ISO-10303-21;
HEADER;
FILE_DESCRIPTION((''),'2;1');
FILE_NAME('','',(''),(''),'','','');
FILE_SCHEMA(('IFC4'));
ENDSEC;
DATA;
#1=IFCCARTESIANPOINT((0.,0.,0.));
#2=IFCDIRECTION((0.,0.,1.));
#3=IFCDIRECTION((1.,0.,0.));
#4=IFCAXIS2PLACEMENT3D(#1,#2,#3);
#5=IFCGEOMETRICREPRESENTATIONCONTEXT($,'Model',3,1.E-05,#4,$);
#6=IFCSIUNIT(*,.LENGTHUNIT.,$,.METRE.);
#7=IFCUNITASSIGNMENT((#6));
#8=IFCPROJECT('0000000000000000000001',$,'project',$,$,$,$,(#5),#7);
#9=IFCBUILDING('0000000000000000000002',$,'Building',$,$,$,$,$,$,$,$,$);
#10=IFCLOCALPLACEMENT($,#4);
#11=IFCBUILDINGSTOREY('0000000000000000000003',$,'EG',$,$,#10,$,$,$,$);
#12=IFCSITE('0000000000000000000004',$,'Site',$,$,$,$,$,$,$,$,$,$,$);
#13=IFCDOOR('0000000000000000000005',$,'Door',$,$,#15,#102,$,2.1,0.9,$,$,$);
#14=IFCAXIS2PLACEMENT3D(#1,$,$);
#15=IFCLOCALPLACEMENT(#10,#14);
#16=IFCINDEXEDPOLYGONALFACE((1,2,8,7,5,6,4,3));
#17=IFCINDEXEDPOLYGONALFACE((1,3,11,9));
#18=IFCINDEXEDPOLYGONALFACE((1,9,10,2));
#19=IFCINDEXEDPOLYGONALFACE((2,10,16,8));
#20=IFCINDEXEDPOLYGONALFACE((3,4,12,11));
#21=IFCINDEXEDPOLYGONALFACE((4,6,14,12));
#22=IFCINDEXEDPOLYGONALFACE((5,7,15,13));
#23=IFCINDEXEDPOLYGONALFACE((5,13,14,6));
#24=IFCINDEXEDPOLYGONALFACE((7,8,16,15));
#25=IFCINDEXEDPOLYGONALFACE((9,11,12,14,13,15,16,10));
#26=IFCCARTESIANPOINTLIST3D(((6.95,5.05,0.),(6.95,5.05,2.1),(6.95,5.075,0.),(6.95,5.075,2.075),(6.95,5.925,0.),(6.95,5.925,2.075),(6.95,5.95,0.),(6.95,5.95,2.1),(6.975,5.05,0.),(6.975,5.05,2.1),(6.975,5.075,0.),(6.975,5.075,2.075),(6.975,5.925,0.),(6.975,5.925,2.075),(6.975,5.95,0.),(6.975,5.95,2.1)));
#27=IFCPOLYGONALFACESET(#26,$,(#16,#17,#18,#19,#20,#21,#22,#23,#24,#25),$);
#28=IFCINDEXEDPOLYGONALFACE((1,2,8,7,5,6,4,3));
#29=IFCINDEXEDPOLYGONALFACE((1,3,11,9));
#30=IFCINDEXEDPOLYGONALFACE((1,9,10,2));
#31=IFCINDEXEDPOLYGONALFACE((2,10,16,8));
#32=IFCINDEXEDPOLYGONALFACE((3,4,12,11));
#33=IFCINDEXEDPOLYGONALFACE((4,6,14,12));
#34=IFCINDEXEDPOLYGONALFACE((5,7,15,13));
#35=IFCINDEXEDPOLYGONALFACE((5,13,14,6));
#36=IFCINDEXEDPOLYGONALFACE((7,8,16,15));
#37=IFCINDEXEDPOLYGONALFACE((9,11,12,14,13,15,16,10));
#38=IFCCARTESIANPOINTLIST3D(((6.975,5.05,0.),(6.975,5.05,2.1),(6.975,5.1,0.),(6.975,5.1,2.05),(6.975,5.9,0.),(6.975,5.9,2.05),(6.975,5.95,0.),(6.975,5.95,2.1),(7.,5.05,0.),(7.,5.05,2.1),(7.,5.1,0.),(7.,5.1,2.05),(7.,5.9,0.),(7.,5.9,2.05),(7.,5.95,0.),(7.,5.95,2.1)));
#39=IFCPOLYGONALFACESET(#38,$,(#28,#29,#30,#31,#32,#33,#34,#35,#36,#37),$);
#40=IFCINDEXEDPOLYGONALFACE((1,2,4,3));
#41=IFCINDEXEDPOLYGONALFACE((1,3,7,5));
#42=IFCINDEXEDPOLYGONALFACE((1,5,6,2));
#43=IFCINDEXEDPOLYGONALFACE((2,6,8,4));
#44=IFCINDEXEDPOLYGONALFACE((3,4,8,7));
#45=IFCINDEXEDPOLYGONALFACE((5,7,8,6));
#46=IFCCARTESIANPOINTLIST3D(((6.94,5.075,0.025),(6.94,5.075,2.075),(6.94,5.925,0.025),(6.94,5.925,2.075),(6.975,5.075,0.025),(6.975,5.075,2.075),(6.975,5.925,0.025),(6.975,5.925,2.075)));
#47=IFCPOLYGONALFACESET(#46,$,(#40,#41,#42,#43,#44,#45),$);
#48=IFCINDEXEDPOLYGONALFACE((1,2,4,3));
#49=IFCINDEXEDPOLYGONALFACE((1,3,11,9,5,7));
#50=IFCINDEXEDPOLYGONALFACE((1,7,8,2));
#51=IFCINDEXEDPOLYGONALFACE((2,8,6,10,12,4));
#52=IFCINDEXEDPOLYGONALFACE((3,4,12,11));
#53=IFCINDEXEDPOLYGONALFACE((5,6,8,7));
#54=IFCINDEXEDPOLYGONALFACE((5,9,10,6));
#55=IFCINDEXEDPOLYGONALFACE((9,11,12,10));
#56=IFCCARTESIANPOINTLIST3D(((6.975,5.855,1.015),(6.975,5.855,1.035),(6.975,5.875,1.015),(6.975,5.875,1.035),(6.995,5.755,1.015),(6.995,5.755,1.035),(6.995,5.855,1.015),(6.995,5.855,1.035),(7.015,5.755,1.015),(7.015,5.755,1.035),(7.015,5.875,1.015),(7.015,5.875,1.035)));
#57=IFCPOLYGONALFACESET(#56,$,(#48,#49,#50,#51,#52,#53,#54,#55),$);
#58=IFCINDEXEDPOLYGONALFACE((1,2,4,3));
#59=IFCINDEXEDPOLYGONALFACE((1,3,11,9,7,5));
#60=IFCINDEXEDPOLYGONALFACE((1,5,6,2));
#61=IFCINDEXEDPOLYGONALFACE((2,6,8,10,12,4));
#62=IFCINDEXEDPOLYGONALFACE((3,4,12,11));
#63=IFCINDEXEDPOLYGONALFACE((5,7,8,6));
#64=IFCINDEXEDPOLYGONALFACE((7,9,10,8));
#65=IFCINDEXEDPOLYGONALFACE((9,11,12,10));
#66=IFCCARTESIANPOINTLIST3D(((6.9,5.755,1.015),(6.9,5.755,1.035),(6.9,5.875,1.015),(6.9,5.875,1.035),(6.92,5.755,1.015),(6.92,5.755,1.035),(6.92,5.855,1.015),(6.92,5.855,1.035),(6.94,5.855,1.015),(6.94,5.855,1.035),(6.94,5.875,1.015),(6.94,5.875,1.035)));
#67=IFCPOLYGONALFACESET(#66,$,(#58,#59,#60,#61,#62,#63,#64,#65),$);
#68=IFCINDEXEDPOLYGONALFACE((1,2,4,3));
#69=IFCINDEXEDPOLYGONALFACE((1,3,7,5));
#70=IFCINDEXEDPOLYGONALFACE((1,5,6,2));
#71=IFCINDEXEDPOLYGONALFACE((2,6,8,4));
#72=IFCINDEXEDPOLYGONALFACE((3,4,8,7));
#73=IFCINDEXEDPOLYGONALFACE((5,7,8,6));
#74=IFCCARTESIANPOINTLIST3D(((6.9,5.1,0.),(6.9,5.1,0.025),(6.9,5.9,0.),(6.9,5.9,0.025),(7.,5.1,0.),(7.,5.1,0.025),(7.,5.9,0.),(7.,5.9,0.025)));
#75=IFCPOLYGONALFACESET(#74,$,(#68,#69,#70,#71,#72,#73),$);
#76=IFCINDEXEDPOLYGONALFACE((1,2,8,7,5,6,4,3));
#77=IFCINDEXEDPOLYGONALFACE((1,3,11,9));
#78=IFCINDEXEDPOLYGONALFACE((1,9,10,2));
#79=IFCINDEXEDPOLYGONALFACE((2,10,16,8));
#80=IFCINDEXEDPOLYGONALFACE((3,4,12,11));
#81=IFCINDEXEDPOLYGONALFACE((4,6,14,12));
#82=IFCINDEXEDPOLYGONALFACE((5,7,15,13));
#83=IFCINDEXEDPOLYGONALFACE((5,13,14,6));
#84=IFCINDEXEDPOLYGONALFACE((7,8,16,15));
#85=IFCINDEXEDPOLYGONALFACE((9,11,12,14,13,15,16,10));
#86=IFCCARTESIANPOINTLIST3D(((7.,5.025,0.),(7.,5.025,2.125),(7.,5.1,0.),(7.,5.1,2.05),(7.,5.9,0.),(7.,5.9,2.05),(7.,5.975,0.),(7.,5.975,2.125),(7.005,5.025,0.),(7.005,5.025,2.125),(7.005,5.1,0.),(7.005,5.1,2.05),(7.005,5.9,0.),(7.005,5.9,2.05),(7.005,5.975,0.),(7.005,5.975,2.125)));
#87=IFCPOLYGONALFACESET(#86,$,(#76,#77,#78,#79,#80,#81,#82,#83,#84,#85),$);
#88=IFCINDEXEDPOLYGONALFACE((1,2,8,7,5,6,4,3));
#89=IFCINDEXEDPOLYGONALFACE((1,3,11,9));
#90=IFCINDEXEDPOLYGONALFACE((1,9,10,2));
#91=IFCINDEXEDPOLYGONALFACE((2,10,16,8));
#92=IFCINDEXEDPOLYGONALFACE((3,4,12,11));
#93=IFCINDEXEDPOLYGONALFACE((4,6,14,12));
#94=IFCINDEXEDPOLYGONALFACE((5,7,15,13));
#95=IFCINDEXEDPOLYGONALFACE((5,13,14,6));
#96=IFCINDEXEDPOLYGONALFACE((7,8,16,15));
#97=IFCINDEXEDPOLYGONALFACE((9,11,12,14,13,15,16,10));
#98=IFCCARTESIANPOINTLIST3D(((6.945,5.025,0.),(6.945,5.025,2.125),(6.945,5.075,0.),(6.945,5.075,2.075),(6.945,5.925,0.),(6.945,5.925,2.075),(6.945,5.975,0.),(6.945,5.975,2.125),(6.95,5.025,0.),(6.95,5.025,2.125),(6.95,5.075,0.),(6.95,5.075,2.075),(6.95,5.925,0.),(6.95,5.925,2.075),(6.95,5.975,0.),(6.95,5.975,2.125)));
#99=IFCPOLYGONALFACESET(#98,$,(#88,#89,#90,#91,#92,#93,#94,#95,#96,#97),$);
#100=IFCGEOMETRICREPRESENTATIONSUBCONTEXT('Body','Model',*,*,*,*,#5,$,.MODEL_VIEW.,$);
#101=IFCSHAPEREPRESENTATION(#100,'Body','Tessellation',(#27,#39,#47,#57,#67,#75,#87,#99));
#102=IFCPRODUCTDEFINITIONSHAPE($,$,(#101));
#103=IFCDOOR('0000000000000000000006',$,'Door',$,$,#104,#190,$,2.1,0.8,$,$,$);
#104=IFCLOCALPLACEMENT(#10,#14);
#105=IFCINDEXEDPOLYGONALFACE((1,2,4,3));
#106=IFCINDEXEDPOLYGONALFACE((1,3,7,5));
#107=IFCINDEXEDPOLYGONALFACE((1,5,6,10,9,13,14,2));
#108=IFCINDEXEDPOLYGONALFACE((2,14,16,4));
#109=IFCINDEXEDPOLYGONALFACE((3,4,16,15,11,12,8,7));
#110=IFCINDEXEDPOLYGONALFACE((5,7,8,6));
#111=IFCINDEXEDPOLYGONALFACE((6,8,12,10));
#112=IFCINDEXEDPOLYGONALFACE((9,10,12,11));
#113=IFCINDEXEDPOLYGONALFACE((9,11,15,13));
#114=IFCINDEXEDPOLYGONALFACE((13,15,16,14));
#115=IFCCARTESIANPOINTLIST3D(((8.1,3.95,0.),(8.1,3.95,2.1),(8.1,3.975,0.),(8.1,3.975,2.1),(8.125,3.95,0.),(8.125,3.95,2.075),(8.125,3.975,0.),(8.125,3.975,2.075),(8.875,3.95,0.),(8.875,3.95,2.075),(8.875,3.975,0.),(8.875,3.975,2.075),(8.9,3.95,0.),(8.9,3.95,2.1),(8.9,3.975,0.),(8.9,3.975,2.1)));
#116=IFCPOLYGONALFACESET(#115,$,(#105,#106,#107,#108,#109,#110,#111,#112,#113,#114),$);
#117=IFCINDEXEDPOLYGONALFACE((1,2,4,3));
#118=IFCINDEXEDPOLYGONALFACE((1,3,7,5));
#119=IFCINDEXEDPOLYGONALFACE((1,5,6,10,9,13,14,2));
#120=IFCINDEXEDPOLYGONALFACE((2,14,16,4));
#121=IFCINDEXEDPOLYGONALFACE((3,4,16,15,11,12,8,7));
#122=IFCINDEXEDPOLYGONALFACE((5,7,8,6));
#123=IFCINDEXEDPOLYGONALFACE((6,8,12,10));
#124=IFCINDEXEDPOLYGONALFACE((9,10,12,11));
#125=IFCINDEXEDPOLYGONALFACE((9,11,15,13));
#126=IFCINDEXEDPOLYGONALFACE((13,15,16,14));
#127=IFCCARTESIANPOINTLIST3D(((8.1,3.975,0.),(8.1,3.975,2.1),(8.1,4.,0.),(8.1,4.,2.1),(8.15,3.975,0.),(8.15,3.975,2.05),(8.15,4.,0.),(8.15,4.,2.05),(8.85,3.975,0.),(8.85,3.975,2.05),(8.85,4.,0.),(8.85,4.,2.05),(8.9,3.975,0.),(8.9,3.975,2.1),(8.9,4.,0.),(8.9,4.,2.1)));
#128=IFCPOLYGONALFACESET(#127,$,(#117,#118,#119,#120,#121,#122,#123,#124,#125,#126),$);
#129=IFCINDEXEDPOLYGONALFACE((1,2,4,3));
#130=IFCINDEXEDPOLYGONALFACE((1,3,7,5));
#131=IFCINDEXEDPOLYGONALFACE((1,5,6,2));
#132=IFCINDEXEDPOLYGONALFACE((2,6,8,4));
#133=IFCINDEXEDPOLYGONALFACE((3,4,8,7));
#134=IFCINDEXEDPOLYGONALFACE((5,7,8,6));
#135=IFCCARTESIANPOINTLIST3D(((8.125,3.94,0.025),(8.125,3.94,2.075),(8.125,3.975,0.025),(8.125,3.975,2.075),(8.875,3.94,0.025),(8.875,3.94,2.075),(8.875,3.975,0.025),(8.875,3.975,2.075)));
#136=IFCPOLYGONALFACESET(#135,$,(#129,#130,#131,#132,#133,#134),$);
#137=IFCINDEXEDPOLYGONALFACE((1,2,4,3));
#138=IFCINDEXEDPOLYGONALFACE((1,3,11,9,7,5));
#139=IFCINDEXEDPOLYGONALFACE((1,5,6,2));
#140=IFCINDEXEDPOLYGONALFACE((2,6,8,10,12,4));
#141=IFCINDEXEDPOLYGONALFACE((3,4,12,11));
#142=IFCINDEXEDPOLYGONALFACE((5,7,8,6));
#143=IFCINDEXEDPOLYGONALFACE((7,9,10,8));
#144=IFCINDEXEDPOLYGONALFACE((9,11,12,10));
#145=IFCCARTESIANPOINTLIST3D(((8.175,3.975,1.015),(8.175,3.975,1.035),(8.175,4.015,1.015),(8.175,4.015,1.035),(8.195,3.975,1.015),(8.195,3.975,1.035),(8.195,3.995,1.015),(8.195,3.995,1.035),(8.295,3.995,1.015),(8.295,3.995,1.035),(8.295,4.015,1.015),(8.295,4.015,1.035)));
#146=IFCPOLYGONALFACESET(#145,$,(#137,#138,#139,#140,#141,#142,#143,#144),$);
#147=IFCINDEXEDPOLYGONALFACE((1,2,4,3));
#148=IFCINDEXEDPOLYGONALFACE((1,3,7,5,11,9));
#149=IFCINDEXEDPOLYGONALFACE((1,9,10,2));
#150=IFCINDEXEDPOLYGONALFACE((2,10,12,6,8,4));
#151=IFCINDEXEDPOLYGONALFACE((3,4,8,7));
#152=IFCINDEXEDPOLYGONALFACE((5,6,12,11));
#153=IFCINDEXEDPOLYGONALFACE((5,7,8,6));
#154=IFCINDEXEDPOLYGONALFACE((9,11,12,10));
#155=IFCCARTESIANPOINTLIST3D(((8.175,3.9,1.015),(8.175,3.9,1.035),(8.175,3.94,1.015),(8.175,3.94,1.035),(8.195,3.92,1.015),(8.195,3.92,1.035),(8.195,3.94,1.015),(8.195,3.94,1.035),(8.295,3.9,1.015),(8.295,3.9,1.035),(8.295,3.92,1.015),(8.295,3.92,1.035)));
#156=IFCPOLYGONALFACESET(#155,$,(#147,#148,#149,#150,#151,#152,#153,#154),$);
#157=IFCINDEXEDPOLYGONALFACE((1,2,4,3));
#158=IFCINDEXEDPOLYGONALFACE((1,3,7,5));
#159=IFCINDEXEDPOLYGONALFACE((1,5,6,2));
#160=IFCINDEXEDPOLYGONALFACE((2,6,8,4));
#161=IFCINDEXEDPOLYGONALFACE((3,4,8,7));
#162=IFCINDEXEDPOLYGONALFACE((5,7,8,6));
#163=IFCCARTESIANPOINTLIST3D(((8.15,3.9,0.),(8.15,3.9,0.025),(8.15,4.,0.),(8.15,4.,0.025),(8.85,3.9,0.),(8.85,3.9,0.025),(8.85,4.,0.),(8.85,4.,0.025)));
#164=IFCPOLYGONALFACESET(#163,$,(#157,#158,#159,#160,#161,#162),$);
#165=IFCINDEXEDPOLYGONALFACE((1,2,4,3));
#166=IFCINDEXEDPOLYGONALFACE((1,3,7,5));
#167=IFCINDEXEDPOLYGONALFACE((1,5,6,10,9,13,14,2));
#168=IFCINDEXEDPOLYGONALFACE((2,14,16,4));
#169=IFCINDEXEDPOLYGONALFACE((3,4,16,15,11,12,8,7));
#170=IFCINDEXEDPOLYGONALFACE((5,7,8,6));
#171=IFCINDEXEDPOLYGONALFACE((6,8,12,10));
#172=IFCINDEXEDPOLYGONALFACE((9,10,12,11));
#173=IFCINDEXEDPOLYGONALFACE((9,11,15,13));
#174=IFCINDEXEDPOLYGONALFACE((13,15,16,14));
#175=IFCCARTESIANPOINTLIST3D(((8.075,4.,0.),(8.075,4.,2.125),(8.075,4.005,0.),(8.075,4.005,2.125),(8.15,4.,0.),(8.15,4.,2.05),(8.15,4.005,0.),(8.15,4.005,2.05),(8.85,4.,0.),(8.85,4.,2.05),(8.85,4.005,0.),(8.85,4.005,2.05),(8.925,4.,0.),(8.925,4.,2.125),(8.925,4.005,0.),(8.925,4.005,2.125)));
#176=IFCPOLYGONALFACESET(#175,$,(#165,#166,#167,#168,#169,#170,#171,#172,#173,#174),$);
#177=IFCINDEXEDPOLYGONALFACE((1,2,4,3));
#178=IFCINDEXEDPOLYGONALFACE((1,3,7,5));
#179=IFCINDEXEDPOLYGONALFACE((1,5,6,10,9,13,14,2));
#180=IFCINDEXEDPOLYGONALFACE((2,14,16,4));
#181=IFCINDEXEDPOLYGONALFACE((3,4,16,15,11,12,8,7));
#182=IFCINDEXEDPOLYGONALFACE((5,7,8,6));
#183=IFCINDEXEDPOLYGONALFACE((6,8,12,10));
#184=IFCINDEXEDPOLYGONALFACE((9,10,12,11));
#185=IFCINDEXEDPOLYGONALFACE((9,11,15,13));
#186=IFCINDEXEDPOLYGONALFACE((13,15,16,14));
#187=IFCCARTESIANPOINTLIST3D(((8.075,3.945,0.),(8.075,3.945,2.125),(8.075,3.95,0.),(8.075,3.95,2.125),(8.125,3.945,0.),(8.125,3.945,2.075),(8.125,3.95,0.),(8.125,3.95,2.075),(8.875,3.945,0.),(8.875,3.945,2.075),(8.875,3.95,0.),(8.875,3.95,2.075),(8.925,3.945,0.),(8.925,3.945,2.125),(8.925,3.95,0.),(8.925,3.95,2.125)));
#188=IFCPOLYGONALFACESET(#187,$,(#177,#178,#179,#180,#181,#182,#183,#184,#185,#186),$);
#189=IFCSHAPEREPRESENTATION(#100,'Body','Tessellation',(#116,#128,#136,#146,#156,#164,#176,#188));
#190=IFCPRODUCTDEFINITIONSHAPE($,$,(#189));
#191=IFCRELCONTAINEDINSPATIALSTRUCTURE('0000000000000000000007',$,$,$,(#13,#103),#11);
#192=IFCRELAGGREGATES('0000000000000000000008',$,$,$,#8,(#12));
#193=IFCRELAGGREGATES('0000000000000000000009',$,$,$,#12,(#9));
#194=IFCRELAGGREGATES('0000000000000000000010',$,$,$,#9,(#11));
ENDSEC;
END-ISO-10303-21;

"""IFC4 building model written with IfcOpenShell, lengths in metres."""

from ifc_helpers import new_model, si_unit, frame, origin_with_axes, place, context, subcontext, project, spatial, line, indexed_curve, outline, extrude, element, save


model = new_model("IFC4")

# Units and contexts
model_context = context("Model", 3, precision=1e-05, world=origin_with_axes())
body_context = subcontext(model_context, "Body", "Model", "MODEL_VIEW")
ifc_project = project(units=[si_unit("LENGTHUNIT", "METRE")], contexts=[model_context])

# Site, building, storey
site = spatial("IfcSite", under=ifc_project, Name="Site")
building = spatial("IfcBuilding", under=site, Name="Building")
storey_placement = place(None, origin_with_axes())
storey = spatial("IfcBuildingStorey", under=building, at=storey_placement, Name="EG")

# Doors
door_1_placement = place(storey_placement, frame((7.0, 5.05, 0.0), z_axis=(0.0, 0.0, 1.0), x_axis=(0.0, 1.0, 0.0)))
element("IfcDoor", 1, at=door_1_placement, inside=storey, Name="Door", OverallHeight=2.1, OverallWidth=0.9, context=body_context, shape_type="SweptSolid", body=[
    extrude(outline(indexed_curve([(0.0, 0.0), (0.0, 2.1), (0.9, 2.1), (0.9, 0.0), (0.875, 0.0), (0.875, 2.075), (0.025, 2.075), (0.025, 0.0)], segments=[line(1, 2, 3, 4, 5, 6, 7, 8, 1)])), frame((0.0, 0.025, 0.0), z_axis=(0.0, -1.0, 0.0), x_axis=(1.0, 0.0, 0.0)), (0.0, 0.0, -1.0), 0.025),
    extrude(outline(indexed_curve([(0.0, 0.0), (0.0, 2.1), (0.9, 2.1), (0.9, 0.0), (0.85, 0.0), (0.85, 2.05), (0.05, 2.05), (0.05, 0.0)], segments=[line(1, 2, 3, 4, 5, 6, 7, 8, 1)])), frame((0.0, 0.0, 0.0), z_axis=(0.0, -1.0, 0.0), x_axis=(1.0, 0.0, 0.0)), (0.0, 0.0, -1.0), 0.025),
    extrude(outline(indexed_curve([(0.0, 0.0), (0.85, 0.0), (0.85, 0.035), (0.0, 0.035)], segments=[line(1, 2, 3, 4, 1)])), frame((0.025, 0.025, 0.025), z_axis=(0.0, 0.0, 1.0), x_axis=(1.0, 0.0, 0.0)), (0.0, 0.0, 1.0), 2.05),
    extrude(outline(indexed_curve([(0.0, 0.0), (0.0, -0.04), (-0.12, -0.04), (-0.12, -0.02), (-0.02, -0.02), (-0.02, 0.0)], segments=[line(1, 2, 3, 4, 5, 6, 1)])), frame((0.825, 0.025, 1.015), z_axis=(0.0, 0.0, 1.0), x_axis=(1.0, 0.0, 0.0)), (0.0, 0.0, 1.0), 0.02),
    extrude(outline(indexed_curve([(0.0, 0.0), (0.0, 0.04), (-0.12, 0.04), (-0.12, 0.02), (-0.02, 0.02), (-0.02, 0.0)], segments=[line(1, 2, 3, 4, 5, 6, 1)])), frame((0.825, 0.06, 1.015), z_axis=(0.0, 0.0, 1.0), x_axis=(1.0, 0.0, 0.0)), (0.0, 0.0, 1.0), 0.02),
    extrude(outline(indexed_curve([(0.0, 0.0), (0.8, 0.0), (0.8, 0.1), (0.0, 0.1)], segments=[line(1, 2, 3, 4, 1)])), frame((0.05, 0.0, 0.0), z_axis=(0.0, 0.0, 1.0), x_axis=(1.0, 0.0, 0.0)), (0.0, 0.0, 1.0), 0.025),
    extrude(outline(indexed_curve([(0.0, 0.0), (0.0, 2.125), (0.95, 2.125), (0.95, 0.0), (0.875, 0.0), (0.875, 2.05), (0.075, 2.05), (0.075, 0.0)], segments=[line(1, 2, 3, 4, 5, 6, 7, 8, 1)])), frame((-0.025, -0.005, 0.0), z_axis=(0.0, -1.0, 0.0), x_axis=(1.0, 0.0, 0.0)), (0.0, 0.0, -1.0), 0.005),
    extrude(outline(indexed_curve([(0.0, 0.0), (0.0, 2.125), (0.95, 2.125), (0.95, 0.0), (0.9, 0.0), (0.9, 2.075), (0.05, 2.075), (0.05, 0.0)], segments=[line(1, 2, 3, 4, 5, 6, 7, 8, 1)])), frame((-0.025, 0.05, 0.0), z_axis=(0.0, -1.0, 0.0), x_axis=(1.0, 0.0, 0.0)), (0.0, 0.0, -1.0), 0.005),
])
door_2_placement = place(storey_placement, frame((8.9, 4.0, 0.0), z_axis=(0.0, 0.0, 1.0), x_axis=(-1.0, 0.0, 0.0)))
element("IfcDoor", 2, at=door_2_placement, inside=storey, Name="Door", OverallHeight=2.1, OverallWidth=0.8, context=body_context, shape_type="SweptSolid", body=[
    extrude(outline(indexed_curve([(0.0, 0.0), (0.0, 2.1), (0.8, 2.1), (0.8, 0.0), (0.775, 0.0), (0.775, 2.075), (0.025, 2.075), (0.025, 0.0)], segments=[line(1, 2, 3, 4, 5, 6, 7, 8, 1)])), frame((0.0, 0.025, 0.0), z_axis=(0.0, -1.0, 0.0), x_axis=(1.0, 0.0, 0.0)), (0.0, 0.0, -1.0), 0.025),
    extrude(outline(indexed_curve([(0.0, 0.0), (0.0, 2.1), (0.8, 2.1), (0.8, 0.0), (0.75, 0.0), (0.75, 2.05), (0.05, 2.05), (0.05, 0.0)], segments=[line(1, 2, 3, 4, 5, 6, 7, 8, 1)])), frame((0.0, 0.0, 0.0), z_axis=(0.0, -1.0, 0.0), x_axis=(1.0, 0.0, 0.0)), (0.0, 0.0, -1.0), 0.025),
    extrude(outline(indexed_curve([(0.0, 0.0), (0.75, 0.0), (0.75, 0.035), (0.0, 0.035)], segments=[line(1, 2, 3, 4, 1)])), frame((0.025, 0.025, 0.025), z_axis=(0.0, 0.0, 1.0), x_axis=(1.0, 0.0, 0.0)), (0.0, 0.0, 1.0), 2.05),
    extrude(outline(indexed_curve([(0.0, 0.0), (0.0, -0.04), (-0.12, -0.04), (-0.12, -0.02), (-0.02, -0.02), (-0.02, 0.0)], segments=[line(1, 2, 3, 4, 5, 6, 1)])), frame((0.725, 0.025, 1.015), z_axis=(0.0, 0.0, 1.0), x_axis=(1.0, 0.0, 0.0)), (0.0, 0.0, 1.0), 0.02),
    extrude(outline(indexed_curve([(0.0, 0.0), (0.0, 0.04), (-0.12, 0.04), (-0.12, 0.02), (-0.02, 0.02), (-0.02, 0.0)], segments=[line(1, 2, 3, 4, 5, 6, 1)])), frame((0.725, 0.06, 1.015), z_axis=(0.0, 0.0, 1.0), x_axis=(1.0, 0.0, 0.0)), (0.0, 0.0, 1.0), 0.02),
    extrude(outline(indexed_curve([(0.0, 0.0), (0.7, 0.0), (0.7, 0.1), (0.0, 0.1)], segments=[line(1, 2, 3, 4, 1)])), frame((0.05, 0.0, 0.0), z_axis=(0.0, 0.0, 1.0), x_axis=(1.0, 0.0, 0.0)), (0.0, 0.0, 1.0), 0.025),
    extrude(outline(indexed_curve([(0.0, 0.0), (0.0, 2.125), (0.85, 2.125), (0.85, 0.0), (0.775, 0.0), (0.775, 2.05), (0.075, 2.05), (0.075, 0.0)], segments=[line(1, 2, 3, 4, 5, 6, 7, 8, 1)])), frame((-0.025, -0.005, 0.0), z_axis=(0.0, -1.0, 0.0), x_axis=(1.0, 0.0, 0.0)), (0.0, 0.0, -1.0), 0.005),
    extrude(outline(indexed_curve([(0.0, 0.0), (0.0, 2.125), (0.85, 2.125), (0.85, 0.0), (0.8, 0.0), (0.8, 2.075), (0.05, 2.075), (0.05, 0.0)], segments=[line(1, 2, 3, 4, 5, 6, 7, 8, 1)])), frame((-0.025, 0.05, 0.0), z_axis=(0.0, -1.0, 0.0), x_axis=(1.0, 0.0, 0.0)), (0.0, 0.0, -1.0), 0.005),
])

save(model, "model.ifc")
